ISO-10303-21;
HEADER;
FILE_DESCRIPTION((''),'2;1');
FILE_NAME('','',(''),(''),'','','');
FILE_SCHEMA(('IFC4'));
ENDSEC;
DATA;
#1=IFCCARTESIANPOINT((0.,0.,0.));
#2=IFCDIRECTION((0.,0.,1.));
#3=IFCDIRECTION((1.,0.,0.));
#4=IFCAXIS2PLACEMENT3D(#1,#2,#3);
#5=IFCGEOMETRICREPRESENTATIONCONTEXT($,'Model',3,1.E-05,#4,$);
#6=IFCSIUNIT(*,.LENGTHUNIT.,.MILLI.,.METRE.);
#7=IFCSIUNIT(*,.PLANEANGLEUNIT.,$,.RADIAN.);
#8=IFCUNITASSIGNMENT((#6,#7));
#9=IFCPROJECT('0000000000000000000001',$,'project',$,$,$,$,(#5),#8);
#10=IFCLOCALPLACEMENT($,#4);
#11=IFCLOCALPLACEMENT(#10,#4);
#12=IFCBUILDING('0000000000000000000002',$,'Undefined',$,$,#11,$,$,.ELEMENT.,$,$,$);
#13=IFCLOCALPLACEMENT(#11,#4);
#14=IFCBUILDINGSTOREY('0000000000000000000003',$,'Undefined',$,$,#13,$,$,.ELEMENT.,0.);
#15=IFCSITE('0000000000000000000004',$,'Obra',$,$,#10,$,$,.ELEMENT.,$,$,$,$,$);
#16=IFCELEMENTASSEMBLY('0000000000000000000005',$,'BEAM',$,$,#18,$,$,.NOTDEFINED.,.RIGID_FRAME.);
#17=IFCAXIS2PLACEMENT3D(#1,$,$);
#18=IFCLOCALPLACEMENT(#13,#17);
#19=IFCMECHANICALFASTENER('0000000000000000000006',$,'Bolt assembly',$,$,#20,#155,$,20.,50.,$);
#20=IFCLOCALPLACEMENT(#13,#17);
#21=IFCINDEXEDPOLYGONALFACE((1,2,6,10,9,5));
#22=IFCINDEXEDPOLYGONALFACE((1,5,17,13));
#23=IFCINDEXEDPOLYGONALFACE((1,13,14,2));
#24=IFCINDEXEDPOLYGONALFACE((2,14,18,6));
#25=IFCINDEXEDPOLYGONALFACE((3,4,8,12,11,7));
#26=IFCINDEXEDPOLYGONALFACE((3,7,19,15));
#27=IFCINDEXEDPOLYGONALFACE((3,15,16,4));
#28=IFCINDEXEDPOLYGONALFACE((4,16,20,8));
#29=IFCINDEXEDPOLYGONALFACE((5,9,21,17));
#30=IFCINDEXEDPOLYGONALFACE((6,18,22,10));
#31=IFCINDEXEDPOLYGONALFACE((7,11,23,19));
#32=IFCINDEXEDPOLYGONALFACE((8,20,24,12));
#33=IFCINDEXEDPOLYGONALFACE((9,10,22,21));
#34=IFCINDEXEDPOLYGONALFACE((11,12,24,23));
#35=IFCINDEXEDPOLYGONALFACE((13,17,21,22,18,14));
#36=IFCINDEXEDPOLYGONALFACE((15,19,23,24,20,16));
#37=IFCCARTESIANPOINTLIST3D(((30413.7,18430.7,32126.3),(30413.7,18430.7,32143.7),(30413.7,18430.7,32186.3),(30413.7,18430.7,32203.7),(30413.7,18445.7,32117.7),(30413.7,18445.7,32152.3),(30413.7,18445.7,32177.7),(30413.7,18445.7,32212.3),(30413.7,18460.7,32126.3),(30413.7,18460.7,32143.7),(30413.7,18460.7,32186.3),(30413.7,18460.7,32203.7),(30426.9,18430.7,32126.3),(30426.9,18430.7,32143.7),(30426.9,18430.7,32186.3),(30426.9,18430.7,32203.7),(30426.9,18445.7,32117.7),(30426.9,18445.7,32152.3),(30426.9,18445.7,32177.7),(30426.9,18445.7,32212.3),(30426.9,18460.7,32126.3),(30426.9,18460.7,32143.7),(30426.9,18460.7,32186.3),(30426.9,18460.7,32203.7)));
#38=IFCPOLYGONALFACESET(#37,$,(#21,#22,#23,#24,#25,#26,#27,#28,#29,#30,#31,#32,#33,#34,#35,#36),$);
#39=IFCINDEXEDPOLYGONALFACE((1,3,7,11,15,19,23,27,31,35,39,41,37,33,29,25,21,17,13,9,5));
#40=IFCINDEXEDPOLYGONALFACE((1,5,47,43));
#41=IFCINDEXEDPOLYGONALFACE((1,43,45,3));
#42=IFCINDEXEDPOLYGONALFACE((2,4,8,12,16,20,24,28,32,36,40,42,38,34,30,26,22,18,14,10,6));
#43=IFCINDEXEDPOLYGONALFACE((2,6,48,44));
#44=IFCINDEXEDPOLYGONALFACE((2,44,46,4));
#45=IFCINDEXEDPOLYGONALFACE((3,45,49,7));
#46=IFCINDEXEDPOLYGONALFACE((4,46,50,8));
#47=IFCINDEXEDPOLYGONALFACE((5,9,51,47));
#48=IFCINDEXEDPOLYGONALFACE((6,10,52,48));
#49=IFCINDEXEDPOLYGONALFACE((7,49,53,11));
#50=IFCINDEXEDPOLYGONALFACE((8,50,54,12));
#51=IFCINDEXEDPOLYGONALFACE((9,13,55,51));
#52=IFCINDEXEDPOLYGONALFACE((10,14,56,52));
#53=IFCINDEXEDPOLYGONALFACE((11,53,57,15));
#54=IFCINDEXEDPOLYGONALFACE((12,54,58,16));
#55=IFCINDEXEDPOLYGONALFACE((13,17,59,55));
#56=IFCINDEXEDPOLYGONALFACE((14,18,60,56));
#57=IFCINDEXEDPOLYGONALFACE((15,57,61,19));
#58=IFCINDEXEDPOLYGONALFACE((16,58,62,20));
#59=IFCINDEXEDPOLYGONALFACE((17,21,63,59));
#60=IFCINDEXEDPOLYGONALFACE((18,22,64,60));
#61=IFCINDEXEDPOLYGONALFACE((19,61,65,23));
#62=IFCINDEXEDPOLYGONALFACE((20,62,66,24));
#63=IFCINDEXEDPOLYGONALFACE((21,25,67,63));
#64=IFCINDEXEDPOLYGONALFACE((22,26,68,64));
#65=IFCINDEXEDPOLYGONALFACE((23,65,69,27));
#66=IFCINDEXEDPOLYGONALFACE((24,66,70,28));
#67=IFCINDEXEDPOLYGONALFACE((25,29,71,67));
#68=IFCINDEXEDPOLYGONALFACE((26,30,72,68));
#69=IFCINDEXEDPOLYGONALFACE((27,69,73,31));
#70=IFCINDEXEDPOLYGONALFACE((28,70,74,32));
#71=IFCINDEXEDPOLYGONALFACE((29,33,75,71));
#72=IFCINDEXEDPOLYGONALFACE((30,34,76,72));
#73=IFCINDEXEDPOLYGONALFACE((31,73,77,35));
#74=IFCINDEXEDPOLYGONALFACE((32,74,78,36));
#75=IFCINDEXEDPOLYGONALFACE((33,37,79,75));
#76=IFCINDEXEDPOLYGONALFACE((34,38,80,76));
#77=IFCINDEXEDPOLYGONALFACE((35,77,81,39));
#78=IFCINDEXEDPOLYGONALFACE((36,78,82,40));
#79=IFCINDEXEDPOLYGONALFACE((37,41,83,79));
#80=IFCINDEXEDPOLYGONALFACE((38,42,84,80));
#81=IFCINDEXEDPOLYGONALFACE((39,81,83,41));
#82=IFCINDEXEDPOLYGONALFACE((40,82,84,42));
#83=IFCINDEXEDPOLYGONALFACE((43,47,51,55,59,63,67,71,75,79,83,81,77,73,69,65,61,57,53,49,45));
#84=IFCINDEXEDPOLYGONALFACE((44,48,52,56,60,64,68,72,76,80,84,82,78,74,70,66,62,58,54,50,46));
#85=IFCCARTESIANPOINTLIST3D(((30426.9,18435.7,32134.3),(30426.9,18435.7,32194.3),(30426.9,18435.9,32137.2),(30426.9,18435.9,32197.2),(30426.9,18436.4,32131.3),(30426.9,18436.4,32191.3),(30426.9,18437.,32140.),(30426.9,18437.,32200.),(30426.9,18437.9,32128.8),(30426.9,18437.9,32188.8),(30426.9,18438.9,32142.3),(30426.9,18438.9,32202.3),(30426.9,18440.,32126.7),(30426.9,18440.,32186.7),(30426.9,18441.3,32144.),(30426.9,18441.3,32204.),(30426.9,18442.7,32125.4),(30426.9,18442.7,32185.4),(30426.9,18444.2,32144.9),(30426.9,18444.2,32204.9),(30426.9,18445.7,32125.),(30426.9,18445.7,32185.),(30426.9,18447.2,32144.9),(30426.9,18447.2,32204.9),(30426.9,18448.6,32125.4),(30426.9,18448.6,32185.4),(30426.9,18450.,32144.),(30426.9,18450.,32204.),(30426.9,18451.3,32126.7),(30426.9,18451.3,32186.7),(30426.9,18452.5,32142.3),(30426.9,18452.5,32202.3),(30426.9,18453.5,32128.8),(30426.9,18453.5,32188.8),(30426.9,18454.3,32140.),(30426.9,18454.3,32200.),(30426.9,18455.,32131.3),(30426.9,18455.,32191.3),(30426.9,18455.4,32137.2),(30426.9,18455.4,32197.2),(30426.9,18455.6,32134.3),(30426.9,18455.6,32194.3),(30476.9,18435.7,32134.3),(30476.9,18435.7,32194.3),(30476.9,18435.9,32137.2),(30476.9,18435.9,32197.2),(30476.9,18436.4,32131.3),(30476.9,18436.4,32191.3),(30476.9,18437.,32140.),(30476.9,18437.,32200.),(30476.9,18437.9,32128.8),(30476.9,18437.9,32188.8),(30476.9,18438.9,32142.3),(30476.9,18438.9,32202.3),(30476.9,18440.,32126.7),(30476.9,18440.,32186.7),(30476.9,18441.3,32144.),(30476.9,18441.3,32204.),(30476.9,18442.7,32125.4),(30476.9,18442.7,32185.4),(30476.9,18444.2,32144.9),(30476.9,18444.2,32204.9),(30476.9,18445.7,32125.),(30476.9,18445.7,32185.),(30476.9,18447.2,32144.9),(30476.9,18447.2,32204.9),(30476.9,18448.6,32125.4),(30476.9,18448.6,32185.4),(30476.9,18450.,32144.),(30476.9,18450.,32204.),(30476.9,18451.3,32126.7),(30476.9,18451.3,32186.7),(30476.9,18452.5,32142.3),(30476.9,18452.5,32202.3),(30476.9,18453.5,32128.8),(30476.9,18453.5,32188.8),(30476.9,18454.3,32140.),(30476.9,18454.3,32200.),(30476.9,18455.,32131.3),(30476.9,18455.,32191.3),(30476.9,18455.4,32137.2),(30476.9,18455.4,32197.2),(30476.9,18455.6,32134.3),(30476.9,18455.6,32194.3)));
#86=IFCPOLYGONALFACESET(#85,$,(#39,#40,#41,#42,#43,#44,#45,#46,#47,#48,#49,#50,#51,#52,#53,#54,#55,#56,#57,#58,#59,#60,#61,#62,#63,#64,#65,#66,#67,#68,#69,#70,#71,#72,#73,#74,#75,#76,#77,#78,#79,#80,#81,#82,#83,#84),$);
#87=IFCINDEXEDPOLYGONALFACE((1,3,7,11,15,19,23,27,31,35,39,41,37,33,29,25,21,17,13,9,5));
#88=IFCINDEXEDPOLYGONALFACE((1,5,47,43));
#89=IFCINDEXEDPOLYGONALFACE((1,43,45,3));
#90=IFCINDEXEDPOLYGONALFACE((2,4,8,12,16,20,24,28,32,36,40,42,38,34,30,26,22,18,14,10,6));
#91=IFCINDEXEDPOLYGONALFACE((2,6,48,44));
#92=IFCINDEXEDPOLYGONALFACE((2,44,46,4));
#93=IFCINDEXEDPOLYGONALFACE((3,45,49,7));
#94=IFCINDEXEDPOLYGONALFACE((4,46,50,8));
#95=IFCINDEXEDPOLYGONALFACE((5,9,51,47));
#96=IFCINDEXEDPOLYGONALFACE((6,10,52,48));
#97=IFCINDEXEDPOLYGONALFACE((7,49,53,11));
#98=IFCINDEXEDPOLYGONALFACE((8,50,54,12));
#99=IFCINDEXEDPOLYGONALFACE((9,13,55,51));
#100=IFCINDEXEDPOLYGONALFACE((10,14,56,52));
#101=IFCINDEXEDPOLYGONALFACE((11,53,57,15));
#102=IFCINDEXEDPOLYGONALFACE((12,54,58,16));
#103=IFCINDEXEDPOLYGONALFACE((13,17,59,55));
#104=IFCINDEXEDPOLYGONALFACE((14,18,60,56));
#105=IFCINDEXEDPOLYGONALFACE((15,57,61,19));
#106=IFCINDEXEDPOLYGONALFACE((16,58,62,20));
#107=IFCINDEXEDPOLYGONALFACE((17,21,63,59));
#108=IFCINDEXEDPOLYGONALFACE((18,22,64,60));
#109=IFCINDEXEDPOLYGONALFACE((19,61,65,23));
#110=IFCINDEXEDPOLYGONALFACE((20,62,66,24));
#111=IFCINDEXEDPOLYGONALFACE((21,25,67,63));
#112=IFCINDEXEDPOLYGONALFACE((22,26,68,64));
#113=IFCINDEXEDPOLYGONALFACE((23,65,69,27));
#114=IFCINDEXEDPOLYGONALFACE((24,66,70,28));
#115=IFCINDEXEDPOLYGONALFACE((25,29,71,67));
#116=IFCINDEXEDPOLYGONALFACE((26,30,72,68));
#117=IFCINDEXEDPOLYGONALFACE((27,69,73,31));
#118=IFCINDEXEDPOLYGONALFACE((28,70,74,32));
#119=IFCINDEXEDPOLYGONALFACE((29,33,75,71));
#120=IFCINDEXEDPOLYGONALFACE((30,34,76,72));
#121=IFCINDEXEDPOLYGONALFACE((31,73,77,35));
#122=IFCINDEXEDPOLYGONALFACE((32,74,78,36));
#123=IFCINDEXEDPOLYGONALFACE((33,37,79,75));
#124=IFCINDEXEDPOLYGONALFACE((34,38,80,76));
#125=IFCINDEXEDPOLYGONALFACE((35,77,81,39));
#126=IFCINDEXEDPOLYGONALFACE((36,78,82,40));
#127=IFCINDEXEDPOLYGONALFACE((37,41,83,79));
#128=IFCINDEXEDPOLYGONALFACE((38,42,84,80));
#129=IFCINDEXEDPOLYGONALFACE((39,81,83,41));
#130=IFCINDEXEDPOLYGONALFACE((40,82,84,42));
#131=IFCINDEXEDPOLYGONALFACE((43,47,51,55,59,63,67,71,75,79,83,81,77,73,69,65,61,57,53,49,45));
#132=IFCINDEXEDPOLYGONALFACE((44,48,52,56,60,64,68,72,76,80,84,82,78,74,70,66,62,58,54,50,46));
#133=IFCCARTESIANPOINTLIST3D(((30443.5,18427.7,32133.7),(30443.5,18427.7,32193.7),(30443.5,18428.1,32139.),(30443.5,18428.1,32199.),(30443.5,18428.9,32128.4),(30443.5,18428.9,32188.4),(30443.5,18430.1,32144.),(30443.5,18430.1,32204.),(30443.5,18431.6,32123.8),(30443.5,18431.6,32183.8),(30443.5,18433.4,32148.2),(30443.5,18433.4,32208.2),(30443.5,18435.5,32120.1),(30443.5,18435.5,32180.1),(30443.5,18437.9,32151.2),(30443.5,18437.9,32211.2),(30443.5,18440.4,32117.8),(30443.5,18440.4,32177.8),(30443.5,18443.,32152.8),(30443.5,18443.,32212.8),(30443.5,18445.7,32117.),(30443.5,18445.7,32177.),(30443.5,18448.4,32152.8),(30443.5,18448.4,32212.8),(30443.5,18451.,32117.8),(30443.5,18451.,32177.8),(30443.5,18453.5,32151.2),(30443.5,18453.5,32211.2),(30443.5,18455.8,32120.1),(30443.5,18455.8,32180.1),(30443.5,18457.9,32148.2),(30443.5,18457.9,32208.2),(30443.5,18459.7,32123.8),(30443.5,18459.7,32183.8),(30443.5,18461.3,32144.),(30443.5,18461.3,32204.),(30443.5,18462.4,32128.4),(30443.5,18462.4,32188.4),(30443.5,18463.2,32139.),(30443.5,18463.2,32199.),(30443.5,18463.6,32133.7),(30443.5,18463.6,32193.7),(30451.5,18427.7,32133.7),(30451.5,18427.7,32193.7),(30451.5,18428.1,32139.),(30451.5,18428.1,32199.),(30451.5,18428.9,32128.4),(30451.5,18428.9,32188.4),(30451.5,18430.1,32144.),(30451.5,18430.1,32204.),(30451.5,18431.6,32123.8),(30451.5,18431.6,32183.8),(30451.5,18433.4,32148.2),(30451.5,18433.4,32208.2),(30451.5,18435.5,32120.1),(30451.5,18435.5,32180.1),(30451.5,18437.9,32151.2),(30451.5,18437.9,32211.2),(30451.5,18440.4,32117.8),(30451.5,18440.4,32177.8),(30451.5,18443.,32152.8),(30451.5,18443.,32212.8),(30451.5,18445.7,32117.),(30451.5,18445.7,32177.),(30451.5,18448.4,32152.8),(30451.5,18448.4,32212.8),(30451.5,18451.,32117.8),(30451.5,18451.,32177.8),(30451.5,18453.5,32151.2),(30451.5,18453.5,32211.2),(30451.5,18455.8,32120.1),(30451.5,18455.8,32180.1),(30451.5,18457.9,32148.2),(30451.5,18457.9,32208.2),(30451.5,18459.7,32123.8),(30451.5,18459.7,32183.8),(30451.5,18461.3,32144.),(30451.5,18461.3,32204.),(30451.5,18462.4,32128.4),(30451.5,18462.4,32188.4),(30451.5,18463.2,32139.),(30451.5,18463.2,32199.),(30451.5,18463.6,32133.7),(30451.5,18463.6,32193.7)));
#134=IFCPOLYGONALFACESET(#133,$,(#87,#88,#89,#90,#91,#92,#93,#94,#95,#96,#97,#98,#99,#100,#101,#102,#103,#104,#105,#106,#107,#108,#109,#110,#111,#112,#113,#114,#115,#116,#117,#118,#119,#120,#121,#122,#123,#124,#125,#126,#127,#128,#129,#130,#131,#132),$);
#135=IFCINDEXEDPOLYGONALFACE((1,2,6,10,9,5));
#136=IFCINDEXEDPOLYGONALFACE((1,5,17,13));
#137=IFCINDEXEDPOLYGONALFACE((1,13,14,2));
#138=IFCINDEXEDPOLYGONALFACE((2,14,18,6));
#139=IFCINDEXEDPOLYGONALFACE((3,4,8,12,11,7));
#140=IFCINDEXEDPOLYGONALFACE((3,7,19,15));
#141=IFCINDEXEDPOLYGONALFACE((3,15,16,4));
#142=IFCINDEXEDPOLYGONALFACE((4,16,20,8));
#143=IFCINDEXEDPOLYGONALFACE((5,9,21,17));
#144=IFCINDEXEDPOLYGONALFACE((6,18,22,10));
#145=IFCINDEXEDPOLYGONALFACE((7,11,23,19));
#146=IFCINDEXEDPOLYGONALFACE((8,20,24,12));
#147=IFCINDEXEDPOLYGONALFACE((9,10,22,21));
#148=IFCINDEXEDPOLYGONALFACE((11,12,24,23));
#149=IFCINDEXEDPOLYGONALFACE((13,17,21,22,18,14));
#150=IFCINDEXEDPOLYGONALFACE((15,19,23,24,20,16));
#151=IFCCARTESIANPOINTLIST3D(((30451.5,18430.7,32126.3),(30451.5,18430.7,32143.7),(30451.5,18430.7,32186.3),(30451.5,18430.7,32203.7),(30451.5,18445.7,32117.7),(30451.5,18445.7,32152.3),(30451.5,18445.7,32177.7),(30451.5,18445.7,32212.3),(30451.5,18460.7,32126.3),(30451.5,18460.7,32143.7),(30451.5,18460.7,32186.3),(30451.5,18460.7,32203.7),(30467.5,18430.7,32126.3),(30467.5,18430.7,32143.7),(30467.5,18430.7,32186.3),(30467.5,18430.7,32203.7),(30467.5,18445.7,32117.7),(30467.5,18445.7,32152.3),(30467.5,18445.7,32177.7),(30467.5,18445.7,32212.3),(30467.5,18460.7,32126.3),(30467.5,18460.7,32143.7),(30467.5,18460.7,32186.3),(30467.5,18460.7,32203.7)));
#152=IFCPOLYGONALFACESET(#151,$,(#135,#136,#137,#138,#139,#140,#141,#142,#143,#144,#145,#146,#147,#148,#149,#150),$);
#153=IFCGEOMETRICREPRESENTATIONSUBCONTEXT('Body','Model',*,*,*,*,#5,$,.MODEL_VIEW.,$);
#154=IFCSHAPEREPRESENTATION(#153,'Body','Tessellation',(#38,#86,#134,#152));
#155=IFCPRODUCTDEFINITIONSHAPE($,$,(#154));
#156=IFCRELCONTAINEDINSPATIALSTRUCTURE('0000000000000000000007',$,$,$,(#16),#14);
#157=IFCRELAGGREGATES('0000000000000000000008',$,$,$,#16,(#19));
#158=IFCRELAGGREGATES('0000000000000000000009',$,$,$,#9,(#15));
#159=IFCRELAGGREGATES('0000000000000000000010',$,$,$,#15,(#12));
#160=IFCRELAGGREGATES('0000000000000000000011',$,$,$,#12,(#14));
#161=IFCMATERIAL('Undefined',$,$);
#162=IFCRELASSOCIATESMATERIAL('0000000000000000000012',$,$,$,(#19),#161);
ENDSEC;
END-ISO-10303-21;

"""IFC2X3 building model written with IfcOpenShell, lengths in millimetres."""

from ifc_helpers import new_model, si_unit, frame, origin_with_axes, origin_2d_with_axis, place, context, subcontext, project, spatial, polyline, circle, outline, extrude, source, transform, mapped, material, element, aggregate, save


model = new_model("IFC2X3")

# Units and contexts
model_context = context("Model", 3, precision=1e-05, world=origin_with_axes())
body_context = subcontext(model_context, "Body", "Model", "MODEL_VIEW")
ifc_project = project(units=[si_unit("LENGTHUNIT", "METRE", prefix="MILLI"), si_unit("PLANEANGLEUNIT", "RADIAN")], contexts=[model_context])

# Site, building, storey
site_placement = place(None, origin_with_axes())
site = spatial("IfcSite", under=ifc_project, at=site_placement, Name="Obra", CompositionType="ELEMENT")
building_placement = place(site_placement, origin_with_axes())
building = spatial("IfcBuilding", under=site, at=building_placement, Name="Undefined", CompositionType="ELEMENT")
storey_placement = place(building_placement, origin_with_axes())
storey = spatial("IfcBuildingStorey", under=building, at=storey_placement, Name="Undefined", CompositionType="ELEMENT", Elevation=0.0)

# Shared definitions
ifc_material_1 = material(Name="Undefined")
shared_shape_1 = source(origin_with_axes(), body_context, "Body", "SweptSolid", [
    extrude(outline(polyline([(17.3, 0.0), (8.7, 15.0), (-8.7, 15.0), (-17.3, 0.0), (-8.7, -15.0), (8.7, -15.0), (17.3, 0.0)])), frame((0.0, -26.5, 0.0), z_axis=(0.0, 1.0, 0.0), x_axis=(1.0, 0.0, 0.0)), (0.0, 0.0, 1.0), 13.2),
    extrude(circle(Radius=10.0, at=origin_2d_with_axis()), frame((0.0, -13.3, 0.0), z_axis=(0.0, 1.0, 0.0), x_axis=(1.0, 0.0, 0.0)), (0.0, 0.0, 1.0), 50.0),
    extrude(circle(Radius=18.0, at=origin_2d_with_axis()), frame((0.0, 3.3, 0.0), z_axis=(0.0, 1.0, 0.0), x_axis=(1.0, 0.0, 0.0)), (0.0, 0.0, 1.0), 8.0),
    extrude(outline(polyline([(17.3, 0.0), (8.7, 15.0), (-8.7, 15.0), (-17.3, 0.0), (-8.7, -15.0), (8.7, -15.0), (17.3, 0.0)])), frame((0.0, 11.3, 0.0), z_axis=(0.0, 1.0, 0.0), x_axis=(1.0, 0.0, 0.0)), (0.0, 0.0, 1.0), 16.0),
])

# Element assembly, mechanical fastener
assembly_1_placement = place(storey_placement, origin_with_axes())
assembly_1 = element("IfcElementAssembly", 1, at=assembly_1_placement, inside=storey, Name="BEAM", AssemblyPlace="NOTDEFINED", PredefinedType="RIGID_FRAME")
mechanical_fastener_1_placement = place(assembly_1_placement, frame((30440.2, 18485.7, 32235.0), z_axis=(0.0, -1.0, 0.0), x_axis=(0.0, 0.0, -1.0)))
mechanical_fastener_1 = element("IfcMechanicalFastener", 2, at=mechanical_fastener_1_placement, material=ifc_material_1, Name="Bolt assembly", NominalDiameter=20.0, NominalLength=50.0, context=body_context, shape_type="MappedRepresentation", body=[
    mapped(shared_shape_1, transform((40.0, 0.0, 40.0))),
    mapped(shared_shape_1, transform((100.0, 0.0, 40.0))),
])
aggregate(assembly_1, [mechanical_fastener_1])

save(model, "model.ifc")
